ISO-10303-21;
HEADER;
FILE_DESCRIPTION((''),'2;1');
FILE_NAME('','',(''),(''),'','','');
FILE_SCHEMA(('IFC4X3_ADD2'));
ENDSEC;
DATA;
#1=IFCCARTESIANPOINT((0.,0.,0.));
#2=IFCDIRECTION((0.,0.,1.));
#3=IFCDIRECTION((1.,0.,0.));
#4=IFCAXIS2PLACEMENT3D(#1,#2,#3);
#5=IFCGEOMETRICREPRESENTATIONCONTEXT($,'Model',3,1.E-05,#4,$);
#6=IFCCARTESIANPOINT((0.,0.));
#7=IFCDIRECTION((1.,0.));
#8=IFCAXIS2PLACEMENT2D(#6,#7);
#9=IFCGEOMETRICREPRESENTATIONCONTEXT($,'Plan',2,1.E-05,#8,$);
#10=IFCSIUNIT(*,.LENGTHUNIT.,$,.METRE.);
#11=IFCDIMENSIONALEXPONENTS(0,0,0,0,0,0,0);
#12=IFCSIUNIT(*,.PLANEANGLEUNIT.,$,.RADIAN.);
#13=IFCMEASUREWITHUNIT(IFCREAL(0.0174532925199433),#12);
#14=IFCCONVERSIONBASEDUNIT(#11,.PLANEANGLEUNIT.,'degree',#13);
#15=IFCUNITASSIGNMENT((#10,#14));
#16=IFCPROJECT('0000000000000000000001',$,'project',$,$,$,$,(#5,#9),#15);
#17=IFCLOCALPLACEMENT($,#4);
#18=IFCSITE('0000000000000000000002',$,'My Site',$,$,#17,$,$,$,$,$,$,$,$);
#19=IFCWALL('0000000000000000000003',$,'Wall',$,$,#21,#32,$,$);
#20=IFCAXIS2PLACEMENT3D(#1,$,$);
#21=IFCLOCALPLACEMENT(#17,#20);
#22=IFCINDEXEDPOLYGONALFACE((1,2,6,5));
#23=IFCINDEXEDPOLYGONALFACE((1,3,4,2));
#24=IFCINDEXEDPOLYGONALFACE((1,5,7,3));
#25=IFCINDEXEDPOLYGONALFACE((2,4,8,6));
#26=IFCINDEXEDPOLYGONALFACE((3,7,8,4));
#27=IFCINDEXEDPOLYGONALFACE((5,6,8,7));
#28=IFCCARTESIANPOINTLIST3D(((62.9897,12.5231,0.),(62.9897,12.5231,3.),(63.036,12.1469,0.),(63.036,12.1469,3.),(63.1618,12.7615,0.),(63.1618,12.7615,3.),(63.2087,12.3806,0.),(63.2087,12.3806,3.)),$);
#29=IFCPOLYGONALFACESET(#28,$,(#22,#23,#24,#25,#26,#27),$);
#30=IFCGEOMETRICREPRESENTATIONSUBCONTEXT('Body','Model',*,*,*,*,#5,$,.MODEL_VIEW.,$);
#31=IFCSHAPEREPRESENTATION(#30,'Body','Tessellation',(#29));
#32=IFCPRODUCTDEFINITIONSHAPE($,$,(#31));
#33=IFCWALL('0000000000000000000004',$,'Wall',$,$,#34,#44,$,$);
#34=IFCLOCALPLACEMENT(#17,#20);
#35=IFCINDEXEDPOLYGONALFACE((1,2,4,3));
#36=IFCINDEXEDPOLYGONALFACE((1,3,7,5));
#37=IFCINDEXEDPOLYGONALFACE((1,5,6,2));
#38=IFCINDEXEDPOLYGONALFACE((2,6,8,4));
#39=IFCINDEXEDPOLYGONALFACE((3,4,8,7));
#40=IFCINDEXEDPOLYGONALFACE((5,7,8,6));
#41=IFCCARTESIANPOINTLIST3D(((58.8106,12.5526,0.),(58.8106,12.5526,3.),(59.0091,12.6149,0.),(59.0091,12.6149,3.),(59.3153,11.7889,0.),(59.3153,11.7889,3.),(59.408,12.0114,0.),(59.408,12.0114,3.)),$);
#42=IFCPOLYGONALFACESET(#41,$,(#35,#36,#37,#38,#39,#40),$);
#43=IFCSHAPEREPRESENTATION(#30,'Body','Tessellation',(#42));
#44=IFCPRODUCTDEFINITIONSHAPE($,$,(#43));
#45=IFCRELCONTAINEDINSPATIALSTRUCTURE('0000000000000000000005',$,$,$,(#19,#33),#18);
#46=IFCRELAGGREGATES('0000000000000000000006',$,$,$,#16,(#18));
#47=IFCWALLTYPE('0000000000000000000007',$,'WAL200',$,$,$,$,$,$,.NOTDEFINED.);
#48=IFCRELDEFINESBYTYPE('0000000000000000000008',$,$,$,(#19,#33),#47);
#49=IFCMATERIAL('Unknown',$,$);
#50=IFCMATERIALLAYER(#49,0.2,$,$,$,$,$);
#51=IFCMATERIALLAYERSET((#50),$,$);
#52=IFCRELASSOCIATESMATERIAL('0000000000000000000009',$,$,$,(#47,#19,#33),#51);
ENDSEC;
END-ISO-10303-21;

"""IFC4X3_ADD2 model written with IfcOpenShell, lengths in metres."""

from ifc_helpers import new_model, entity, si_unit, converted_unit, frame, origin_with_axes, origin_2d_with_axis, place, context, subcontext, project, spatial, line, indexed_curve, outline, extrude, material, layer, layer_set, layer_usage, type_object, element, save


model = new_model("IFC4X3_ADD2")

# Units and contexts
model_context = context("Model", 3, precision=1e-05, world=origin_with_axes())
plan_context = context("Plan", 2, precision=1e-05, world=origin_2d_with_axis())
body_context = subcontext(model_context, "Body", "Model", "MODEL_VIEW")
ifc_project = project(units=[si_unit("LENGTHUNIT", "METRE"), converted_unit("PLANEANGLEUNIT", "degree", entity("IfcReal", 0.0174532925199433), si_unit("PLANEANGLEUNIT", "RADIAN"), dimensions=[0, 0, 0, 0, 0, 0, 0])], contexts=[model_context, plan_context])

# Site
site_placement = place(None, origin_with_axes())
site = spatial("IfcSite", under=ifc_project, at=site_placement, Name="My Site")

# Walls
ifc_material = material(Name="Unknown")
ifc_layer = layer(ifc_material, 0.2)
ifc_layer_set = layer_set([ifc_layer])
wall_type = type_object("IfcWallType", Name="WAL200", PredefinedType="NOTDEFINED", material=ifc_layer_set)
ifc_layer_usage_1 = layer_usage(ifc_layer_set, "AXIS2", "POSITIVE", 0.0)
wall_1_placement = place(site_placement, frame((63.2087, 12.3806, 0.0), z_axis=(0.0, 0.0, 1.0), x_axis=(-0.122325, 0.99249, 0.0)))
element("IfcWall", 1, at=wall_1_placement, inside=site, type_object=wall_type, material=ifc_layer_usage_1, Name="Wall", context=body_context, shape_type="SweptSolid", body=[
    extrude(outline(indexed_curve([(0.0, 0.0), (-0.2108, 0.2), (0.1683, 0.2), (0.3838, 0.0)], segments=[line(1, 2, 3, 4, 1)])), origin_with_axes(), (0.0, 0.0, 1.0), 3.0),
])
ifc_layer_usage_2 = layer_usage(ifc_layer_set, "AXIS2", "POSITIVE", 0.0)
wall_2_placement = place(site_placement, frame((59.408, 12.0114, 0.0), z_axis=(0.0, 0.0, 1.0), x_axis=(-0.5514, 0.834241, 0.0)))
element("IfcWall", 2, at=wall_2_placement, inside=site, type_object=wall_type, material=ifc_layer_usage_2, Name="Wall", context=body_context, shape_type="SweptSolid", body=[
    extrude(outline(indexed_curve([(0.0, 0.0), (-0.1345, 0.2), (0.7809, 0.2), (0.7234, 0.0)], segments=[line(1, 2, 3, 4, 1)])), origin_with_axes(), (0.0, 0.0, 1.0), 3.0),
])

save(model, "model.ifc")
